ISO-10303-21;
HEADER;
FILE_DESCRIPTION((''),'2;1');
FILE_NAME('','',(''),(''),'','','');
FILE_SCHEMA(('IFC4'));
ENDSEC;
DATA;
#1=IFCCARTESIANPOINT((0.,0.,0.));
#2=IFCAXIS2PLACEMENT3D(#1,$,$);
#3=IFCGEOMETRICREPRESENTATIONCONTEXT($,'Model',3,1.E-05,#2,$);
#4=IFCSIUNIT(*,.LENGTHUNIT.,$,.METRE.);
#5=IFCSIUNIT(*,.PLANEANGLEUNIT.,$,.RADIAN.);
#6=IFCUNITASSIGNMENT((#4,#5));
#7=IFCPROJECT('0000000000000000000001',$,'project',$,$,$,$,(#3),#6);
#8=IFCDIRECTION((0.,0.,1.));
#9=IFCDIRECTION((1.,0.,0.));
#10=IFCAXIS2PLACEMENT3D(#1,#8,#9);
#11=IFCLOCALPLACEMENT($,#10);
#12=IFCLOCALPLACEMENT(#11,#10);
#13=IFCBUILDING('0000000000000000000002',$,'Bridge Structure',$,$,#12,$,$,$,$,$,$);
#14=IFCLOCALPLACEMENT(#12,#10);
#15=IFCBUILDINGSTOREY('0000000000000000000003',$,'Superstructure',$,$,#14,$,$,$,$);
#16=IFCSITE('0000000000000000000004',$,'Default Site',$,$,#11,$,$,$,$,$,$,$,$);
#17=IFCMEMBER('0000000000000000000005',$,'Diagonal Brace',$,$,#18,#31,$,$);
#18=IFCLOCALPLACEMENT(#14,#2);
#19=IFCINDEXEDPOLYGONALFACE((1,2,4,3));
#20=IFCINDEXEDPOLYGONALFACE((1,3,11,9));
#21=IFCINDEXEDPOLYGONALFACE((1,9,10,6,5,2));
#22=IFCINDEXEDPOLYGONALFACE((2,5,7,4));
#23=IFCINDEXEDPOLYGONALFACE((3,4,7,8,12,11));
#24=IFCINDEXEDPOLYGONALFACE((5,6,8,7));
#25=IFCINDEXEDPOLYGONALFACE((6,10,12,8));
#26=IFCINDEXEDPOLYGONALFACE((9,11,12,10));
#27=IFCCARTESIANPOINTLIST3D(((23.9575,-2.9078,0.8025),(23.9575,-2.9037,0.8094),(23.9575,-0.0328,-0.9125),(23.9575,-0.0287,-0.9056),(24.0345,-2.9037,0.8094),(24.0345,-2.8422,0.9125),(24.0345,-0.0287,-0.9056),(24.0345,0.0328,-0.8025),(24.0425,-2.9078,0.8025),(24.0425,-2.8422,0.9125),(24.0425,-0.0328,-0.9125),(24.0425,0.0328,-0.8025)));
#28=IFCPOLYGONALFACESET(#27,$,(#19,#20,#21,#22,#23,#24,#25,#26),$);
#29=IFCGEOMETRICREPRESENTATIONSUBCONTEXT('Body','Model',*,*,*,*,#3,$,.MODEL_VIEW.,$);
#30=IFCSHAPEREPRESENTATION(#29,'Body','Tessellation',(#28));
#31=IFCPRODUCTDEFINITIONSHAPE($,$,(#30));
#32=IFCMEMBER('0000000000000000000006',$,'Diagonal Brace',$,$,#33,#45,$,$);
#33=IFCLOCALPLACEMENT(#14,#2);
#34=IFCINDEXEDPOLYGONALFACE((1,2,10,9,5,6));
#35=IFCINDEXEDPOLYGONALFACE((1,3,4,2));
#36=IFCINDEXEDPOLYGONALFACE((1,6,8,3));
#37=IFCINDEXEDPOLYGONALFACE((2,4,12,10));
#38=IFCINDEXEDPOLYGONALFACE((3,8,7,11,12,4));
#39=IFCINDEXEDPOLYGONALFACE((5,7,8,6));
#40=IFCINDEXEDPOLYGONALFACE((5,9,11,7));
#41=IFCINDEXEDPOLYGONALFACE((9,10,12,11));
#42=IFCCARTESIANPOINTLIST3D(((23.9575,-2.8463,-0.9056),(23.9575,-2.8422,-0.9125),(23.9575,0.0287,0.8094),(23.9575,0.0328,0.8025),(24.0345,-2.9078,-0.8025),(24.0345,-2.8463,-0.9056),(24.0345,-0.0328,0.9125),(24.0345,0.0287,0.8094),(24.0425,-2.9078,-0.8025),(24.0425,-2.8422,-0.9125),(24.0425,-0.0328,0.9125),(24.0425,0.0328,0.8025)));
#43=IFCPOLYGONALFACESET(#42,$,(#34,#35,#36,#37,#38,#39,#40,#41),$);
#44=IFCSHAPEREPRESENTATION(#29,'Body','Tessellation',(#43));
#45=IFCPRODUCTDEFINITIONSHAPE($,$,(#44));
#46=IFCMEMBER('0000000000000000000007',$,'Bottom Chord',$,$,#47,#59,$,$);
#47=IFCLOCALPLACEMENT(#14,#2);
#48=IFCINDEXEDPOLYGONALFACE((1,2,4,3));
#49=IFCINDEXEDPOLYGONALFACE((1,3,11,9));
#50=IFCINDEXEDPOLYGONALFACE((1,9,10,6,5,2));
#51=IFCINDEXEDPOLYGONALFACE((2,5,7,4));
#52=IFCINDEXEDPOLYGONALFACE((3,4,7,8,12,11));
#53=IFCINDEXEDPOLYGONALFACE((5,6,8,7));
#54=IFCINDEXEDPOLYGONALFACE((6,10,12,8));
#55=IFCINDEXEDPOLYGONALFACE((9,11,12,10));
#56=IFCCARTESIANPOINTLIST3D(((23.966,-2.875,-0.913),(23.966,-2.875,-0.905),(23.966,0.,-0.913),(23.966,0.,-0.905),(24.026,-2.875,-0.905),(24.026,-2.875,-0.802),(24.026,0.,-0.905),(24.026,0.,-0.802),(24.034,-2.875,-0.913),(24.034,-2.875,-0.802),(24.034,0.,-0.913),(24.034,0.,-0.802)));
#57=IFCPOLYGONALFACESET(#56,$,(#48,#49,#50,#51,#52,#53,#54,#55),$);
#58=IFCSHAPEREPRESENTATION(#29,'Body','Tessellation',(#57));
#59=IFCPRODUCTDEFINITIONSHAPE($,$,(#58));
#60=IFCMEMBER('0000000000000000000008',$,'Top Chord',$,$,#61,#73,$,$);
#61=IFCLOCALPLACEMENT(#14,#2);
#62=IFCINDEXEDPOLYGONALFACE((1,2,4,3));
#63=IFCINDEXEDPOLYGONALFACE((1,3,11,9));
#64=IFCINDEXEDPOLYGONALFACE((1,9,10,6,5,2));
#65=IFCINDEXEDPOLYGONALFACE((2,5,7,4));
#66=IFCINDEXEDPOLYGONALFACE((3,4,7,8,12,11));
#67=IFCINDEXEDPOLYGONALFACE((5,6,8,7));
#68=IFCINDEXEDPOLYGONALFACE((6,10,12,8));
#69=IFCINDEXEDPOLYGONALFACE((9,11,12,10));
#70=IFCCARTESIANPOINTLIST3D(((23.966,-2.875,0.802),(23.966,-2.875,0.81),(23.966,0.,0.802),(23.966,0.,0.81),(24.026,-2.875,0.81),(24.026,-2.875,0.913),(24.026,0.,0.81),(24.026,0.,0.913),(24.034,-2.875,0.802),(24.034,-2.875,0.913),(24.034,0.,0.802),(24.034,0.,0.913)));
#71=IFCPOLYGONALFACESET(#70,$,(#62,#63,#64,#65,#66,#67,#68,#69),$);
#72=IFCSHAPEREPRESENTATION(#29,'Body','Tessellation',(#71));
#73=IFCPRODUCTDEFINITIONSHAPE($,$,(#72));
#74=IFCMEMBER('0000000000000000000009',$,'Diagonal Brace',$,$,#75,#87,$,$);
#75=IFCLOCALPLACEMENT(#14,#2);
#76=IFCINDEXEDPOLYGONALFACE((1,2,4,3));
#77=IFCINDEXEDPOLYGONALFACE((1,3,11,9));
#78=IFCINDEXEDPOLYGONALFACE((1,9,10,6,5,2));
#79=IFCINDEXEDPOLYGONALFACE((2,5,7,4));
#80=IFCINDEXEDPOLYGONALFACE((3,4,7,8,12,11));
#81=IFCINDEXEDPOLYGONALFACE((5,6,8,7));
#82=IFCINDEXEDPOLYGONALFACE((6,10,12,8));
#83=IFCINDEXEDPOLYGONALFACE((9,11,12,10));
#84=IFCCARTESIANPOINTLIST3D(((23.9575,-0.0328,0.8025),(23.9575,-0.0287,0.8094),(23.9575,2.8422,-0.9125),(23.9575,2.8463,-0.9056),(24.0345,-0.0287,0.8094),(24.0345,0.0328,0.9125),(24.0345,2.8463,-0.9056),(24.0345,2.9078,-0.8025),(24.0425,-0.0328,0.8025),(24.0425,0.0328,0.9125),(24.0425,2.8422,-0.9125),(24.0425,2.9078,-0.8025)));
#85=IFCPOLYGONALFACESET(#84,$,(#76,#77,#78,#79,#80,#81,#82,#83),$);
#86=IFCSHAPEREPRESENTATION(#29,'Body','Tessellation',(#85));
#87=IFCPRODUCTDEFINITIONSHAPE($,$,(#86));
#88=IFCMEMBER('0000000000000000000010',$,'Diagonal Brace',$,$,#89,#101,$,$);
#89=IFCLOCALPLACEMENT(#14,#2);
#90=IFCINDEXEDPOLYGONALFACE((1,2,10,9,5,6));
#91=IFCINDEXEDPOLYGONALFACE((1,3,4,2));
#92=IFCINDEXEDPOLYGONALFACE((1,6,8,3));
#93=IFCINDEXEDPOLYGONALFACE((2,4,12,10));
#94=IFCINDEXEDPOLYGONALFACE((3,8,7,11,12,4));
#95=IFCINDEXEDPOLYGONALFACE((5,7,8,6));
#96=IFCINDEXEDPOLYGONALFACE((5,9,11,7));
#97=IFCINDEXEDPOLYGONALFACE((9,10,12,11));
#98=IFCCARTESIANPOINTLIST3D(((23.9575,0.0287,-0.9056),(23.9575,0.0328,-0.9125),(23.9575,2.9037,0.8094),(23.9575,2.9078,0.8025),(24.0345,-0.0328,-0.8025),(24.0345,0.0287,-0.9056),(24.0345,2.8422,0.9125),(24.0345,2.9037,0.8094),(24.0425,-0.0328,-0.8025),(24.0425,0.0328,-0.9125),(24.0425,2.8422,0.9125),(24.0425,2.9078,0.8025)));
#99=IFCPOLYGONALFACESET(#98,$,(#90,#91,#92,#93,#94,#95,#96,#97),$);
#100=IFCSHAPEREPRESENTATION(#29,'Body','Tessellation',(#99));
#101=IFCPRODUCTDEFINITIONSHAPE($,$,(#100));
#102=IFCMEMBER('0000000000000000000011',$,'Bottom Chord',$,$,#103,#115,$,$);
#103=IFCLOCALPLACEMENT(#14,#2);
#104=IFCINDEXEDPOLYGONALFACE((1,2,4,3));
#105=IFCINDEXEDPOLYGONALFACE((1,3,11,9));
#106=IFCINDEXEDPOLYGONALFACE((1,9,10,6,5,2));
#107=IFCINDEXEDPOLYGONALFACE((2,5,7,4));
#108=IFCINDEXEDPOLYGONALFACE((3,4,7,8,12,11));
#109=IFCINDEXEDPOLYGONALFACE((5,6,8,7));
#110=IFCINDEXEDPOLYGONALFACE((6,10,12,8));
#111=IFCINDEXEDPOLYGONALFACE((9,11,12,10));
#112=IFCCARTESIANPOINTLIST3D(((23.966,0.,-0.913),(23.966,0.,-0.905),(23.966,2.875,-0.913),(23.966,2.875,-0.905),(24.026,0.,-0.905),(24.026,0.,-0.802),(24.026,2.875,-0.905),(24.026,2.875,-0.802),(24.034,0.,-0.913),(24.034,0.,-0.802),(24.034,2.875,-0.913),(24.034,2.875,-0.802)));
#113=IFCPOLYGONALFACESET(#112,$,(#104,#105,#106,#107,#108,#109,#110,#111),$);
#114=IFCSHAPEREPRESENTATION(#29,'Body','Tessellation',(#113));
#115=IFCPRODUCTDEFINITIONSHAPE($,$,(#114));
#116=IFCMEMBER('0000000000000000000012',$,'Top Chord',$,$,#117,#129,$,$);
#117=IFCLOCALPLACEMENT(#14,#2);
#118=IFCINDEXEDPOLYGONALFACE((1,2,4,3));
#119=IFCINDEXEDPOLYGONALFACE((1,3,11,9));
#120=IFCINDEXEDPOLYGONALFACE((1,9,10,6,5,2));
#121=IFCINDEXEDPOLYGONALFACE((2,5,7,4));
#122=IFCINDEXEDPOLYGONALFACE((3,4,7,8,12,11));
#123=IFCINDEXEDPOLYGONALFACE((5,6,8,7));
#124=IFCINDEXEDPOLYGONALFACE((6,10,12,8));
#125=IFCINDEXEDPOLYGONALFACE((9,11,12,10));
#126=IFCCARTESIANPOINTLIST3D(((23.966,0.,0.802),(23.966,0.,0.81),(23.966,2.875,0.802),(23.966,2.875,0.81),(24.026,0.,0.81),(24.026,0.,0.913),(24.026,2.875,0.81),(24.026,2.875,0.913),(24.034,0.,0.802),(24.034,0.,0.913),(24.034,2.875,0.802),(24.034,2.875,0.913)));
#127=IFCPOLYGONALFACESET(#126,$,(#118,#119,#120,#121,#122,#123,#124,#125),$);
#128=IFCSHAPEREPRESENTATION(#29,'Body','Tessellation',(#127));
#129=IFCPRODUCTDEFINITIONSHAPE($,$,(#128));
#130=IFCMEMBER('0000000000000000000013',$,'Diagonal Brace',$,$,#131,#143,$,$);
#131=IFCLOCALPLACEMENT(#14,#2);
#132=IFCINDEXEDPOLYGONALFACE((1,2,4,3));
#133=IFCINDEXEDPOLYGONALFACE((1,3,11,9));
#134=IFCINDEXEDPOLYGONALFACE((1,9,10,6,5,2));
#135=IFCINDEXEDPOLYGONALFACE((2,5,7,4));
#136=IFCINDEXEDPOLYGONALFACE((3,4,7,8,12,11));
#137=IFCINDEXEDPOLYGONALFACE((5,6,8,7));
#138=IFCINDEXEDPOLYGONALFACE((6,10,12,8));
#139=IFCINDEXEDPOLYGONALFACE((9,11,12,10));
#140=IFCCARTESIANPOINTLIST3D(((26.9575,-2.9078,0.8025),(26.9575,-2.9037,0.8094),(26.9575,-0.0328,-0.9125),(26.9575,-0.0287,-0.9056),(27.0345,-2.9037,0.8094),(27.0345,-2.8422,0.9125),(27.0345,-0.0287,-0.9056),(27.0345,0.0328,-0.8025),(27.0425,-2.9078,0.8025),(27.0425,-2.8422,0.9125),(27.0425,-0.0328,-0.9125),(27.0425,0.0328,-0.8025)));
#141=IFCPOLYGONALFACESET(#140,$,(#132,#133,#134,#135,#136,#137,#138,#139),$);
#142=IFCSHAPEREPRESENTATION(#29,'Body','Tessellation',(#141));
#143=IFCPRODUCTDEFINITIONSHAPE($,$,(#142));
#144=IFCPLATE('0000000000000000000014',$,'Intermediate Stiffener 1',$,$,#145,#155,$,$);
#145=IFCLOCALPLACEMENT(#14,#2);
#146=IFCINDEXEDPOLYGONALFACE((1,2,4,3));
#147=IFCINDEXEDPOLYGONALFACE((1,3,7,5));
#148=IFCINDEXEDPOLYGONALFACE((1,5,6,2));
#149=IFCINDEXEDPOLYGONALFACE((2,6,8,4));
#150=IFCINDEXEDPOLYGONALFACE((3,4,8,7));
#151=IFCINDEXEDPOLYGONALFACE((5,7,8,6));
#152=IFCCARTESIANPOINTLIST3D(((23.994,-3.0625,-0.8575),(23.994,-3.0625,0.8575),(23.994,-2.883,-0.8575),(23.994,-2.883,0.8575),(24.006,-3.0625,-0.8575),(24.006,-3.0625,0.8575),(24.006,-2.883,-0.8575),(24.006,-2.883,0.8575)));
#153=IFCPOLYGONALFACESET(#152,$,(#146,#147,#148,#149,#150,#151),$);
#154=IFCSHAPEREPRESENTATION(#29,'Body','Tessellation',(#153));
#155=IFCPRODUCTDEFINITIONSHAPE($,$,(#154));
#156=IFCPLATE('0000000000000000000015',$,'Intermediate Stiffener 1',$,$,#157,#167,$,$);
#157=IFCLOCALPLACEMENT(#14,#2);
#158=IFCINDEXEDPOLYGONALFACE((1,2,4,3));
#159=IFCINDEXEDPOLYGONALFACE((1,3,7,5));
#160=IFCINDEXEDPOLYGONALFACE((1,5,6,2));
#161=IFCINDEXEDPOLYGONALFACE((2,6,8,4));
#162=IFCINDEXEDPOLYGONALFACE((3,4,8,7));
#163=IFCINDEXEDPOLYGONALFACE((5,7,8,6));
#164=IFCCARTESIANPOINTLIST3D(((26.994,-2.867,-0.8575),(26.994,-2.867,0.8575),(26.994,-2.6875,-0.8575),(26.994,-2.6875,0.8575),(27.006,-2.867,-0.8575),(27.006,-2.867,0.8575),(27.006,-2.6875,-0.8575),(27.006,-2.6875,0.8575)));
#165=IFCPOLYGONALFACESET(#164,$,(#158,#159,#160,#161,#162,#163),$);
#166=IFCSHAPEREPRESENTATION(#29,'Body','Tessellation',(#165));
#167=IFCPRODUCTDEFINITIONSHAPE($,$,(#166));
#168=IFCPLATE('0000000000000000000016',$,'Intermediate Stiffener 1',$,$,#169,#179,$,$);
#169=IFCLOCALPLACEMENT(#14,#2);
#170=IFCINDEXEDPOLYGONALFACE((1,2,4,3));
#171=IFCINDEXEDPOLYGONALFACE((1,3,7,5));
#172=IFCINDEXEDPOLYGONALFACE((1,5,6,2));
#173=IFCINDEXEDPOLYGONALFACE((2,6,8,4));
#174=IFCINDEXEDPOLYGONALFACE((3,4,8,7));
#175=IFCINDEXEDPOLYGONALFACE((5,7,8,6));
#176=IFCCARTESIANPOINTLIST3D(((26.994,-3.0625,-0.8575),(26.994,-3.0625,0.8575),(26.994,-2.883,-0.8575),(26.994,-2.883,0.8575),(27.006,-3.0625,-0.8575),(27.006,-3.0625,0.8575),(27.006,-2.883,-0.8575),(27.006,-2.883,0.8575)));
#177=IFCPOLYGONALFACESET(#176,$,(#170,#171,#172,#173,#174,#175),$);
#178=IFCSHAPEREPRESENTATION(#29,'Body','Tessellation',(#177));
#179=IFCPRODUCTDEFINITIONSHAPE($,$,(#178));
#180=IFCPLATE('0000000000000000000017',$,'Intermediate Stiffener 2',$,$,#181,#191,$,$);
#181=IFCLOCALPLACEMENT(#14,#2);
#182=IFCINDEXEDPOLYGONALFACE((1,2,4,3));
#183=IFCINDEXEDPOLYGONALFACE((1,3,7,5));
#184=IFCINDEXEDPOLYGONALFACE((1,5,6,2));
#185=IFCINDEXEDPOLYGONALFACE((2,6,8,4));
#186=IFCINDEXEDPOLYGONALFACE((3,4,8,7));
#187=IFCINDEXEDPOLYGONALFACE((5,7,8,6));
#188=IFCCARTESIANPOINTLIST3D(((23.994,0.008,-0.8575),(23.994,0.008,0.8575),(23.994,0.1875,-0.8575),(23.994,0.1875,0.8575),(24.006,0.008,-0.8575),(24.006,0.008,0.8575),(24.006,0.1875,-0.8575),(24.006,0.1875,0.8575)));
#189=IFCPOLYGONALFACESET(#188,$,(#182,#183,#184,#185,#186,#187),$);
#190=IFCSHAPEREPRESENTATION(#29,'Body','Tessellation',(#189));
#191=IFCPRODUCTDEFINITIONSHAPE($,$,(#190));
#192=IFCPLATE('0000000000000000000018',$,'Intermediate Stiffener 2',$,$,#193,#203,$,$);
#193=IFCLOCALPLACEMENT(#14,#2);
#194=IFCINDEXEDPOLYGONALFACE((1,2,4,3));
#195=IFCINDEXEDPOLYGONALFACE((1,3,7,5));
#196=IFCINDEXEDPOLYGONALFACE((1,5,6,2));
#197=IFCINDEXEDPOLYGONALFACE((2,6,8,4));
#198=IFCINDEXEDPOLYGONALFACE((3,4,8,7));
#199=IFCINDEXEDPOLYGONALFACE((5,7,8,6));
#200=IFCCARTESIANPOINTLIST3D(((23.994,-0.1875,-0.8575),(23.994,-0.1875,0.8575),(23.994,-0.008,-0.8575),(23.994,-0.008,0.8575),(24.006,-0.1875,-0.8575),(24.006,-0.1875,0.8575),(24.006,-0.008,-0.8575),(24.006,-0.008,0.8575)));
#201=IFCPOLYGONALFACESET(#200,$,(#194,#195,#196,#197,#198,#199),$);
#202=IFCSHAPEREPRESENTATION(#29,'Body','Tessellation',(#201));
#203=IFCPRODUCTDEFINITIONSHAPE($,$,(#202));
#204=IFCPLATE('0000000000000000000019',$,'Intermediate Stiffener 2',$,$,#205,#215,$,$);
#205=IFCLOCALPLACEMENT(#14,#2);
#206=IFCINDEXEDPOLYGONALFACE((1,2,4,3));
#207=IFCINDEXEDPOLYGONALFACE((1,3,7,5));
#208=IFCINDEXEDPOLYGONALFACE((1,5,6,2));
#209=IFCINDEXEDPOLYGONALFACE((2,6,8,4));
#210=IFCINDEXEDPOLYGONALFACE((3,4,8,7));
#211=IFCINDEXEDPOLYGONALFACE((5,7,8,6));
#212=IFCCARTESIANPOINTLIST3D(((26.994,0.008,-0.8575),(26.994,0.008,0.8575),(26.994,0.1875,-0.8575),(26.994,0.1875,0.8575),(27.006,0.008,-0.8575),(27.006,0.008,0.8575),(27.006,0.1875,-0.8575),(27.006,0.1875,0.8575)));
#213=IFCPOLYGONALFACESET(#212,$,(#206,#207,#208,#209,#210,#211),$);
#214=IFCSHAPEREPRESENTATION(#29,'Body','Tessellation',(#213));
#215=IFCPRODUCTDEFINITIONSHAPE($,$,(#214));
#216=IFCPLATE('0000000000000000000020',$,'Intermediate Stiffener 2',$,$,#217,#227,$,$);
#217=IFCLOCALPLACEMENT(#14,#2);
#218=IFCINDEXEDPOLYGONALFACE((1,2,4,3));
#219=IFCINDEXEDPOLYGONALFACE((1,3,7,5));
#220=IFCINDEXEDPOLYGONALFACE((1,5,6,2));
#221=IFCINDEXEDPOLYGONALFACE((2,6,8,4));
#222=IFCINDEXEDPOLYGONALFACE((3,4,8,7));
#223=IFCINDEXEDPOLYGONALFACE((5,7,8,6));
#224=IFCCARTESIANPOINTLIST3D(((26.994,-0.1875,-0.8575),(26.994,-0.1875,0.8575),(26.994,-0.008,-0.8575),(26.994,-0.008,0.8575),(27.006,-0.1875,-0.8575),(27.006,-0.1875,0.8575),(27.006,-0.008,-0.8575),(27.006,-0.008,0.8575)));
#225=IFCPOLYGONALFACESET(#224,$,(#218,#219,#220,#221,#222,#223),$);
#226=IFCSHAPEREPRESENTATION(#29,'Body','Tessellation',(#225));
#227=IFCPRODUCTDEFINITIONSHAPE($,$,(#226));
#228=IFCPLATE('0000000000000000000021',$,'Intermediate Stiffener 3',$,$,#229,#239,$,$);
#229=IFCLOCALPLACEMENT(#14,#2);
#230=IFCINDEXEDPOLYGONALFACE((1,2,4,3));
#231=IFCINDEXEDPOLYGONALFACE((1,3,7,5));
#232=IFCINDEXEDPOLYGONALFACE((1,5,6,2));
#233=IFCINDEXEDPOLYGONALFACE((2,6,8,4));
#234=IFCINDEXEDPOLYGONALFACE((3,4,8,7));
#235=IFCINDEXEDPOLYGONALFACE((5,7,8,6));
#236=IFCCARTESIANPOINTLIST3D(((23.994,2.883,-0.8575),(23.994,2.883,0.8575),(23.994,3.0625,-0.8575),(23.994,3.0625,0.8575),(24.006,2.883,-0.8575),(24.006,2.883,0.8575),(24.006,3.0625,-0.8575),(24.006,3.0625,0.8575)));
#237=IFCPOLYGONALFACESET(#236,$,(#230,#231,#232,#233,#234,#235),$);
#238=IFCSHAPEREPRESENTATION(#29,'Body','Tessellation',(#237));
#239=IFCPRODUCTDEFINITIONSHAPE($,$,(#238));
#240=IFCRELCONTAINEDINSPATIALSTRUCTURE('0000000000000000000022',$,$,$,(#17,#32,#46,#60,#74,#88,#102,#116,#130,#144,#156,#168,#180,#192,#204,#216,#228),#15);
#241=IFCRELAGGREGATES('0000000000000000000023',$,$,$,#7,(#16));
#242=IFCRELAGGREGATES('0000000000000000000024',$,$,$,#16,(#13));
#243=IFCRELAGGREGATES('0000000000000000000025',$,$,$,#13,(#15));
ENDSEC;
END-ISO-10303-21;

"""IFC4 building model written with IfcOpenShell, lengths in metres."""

from ifc_helpers import new_model, si_unit, frame, origin, origin_with_axes, origin_2d_with_axis, place, context, subcontext, project, spatial, rectangle, l_section, extrude, element, save


model = new_model("IFC4")

# Units and contexts
model_context = context("Model", 3, precision=1e-05, world=origin())
body_context = subcontext(model_context, "Body", "Model", "MODEL_VIEW")
ifc_project = project(units=[si_unit("LENGTHUNIT", "METRE"), si_unit("PLANEANGLEUNIT", "RADIAN")], contexts=[model_context])

# Site, building, storey
site_placement = place(None, origin_with_axes())
site = spatial("IfcSite", under=ifc_project, at=site_placement, Name="Default Site")
building_placement = place(site_placement, origin_with_axes())
building = spatial("IfcBuilding", under=site, at=building_placement, Name="Bridge Structure")
storey_placement = place(building_placement, origin_with_axes())
storey = spatial("IfcBuildingStorey", under=building, at=storey_placement, Name="Superstructure")

# Members
for number, where, z_axis, x_axis, name in (
    (1, (24.0, -2.875, 0.8575), (0.0, 0.858808, -0.512298), (-1.0, 0.0, 0.0), "Diagonal Brace"),
    (2, (24.0, -2.875, -0.8575), (0.0, 0.858808, 0.512298), (-1.0, 0.0, 0.0), "Diagonal Brace"),
):
    element("IfcMember", number, at=place(storey_placement, frame(where, z_axis=z_axis, x_axis=x_axis)), inside=storey, Name=name, context=body_context, shape_type="SweptSolid", body=[
        extrude(l_section(Depth=0.128, Width=0.085, Thickness=0.008, at=origin_2d_with_axis()), origin_with_axes(), (0.0, 0.0, 1.0), 3.3477),
    ])
for number, where, z_axis, x_axis, name in (
    (3, (24.0, -2.875, -0.8575), (0.0, 1.0, 0.0), (-1.0, 0.0, 0.0), "Bottom Chord"),
    (4, (24.0, -2.875, 0.8575), (0.0, 1.0, 0.0), (-1.0, 0.0, 0.0), "Top Chord"),
):
    element("IfcMember", number, at=place(storey_placement, frame(where, z_axis=z_axis, x_axis=x_axis)), inside=storey, Name=name, context=body_context, shape_type="SweptSolid", body=[
        extrude(l_section(Depth=0.111, Width=0.068, Thickness=0.008, at=origin_2d_with_axis()), origin_with_axes(), (0.0, 0.0, 1.0), 2.875),
    ])
for number, where, z_axis, x_axis, name in (
    (5, (24.0, 0.0, 0.8575), (0.0, 0.858808, -0.512298), (-1.0, 0.0, 0.0), "Diagonal Brace"),
    (6, (24.0, 0.0, -0.8575), (0.0, 0.858808, 0.512298), (-1.0, 0.0, 0.0), "Diagonal Brace"),
):
    element("IfcMember", number, at=place(storey_placement, frame(where, z_axis=z_axis, x_axis=x_axis)), inside=storey, Name=name, context=body_context, shape_type="SweptSolid", body=[
        extrude(l_section(Depth=0.128, Width=0.085, Thickness=0.008, at=origin_2d_with_axis()), origin_with_axes(), (0.0, 0.0, 1.0), 3.3477),
    ])
for number, where, z_axis, x_axis, name in (
    (7, (24.0, 0.0, -0.8575), (0.0, 1.0, 0.0), (-1.0, 0.0, 0.0), "Bottom Chord"),
    (8, (24.0, 0.0, 0.8575), (0.0, 1.0, 0.0), (-1.0, 0.0, 0.0), "Top Chord"),
):
    element("IfcMember", number, at=place(storey_placement, frame(where, z_axis=z_axis, x_axis=x_axis)), inside=storey, Name=name, context=body_context, shape_type="SweptSolid", body=[
        extrude(l_section(Depth=0.111, Width=0.068, Thickness=0.008, at=origin_2d_with_axis()), origin_with_axes(), (0.0, 0.0, 1.0), 2.875),
    ])
member_placement = place(storey_placement, frame((27.0, -2.875, 0.8575), z_axis=(0.0, 0.858808, -0.512298), x_axis=(-1.0, 0.0, 0.0)))
element("IfcMember", 9, at=member_placement, inside=storey, Name="Diagonal Brace", context=body_context, shape_type="SweptSolid", body=[
    extrude(l_section(Depth=0.128, Width=0.085, Thickness=0.008, at=origin_2d_with_axis()), origin_with_axes(), (0.0, 0.0, 1.0), 3.3477),
])

# Plates
for number, where, z_axis, x_axis, name in (
    (10, (24.0, -2.9728, -0.8575), (0.0, 0.0, 1.0), (1.0, 0.0, 0.0), "Intermediate Stiffener 1"),
    (11, (27.0, -2.7772, -0.8575), (0.0, 0.0, 1.0), (1.0, 0.0, 0.0), "Intermediate Stiffener 1"),
    (12, (27.0, -2.9728, -0.8575), (0.0, 0.0, 1.0), (1.0, 0.0, 0.0), "Intermediate Stiffener 1"),
    (13, (24.0, 0.0978, -0.8575), (0.0, 0.0, 1.0), (1.0, 0.0, 0.0), "Intermediate Stiffener 2"),
    (14, (24.0, -0.0978, -0.8575), (0.0, 0.0, 1.0), (1.0, 0.0, 0.0), "Intermediate Stiffener 2"),
    (15, (27.0, 0.0978, -0.8575), (0.0, 0.0, 1.0), (1.0, 0.0, 0.0), "Intermediate Stiffener 2"),
    (16, (27.0, -0.0978, -0.8575), (0.0, 0.0, 1.0), (1.0, 0.0, 0.0), "Intermediate Stiffener 2"),
    (17, (24.0, 2.9728, -0.8575), (0.0, 0.0, 1.0), (1.0, 0.0, 0.0), "Intermediate Stiffener 3"),
):
    element("IfcPlate", number, at=place(storey_placement, frame(where, z_axis=z_axis, x_axis=x_axis)), inside=storey, Name=name, context=body_context, shape_type="SweptSolid", body=[
        extrude(rectangle(XDim=0.012, YDim=0.1795, at=origin_2d_with_axis()), origin_with_axes(), (0.0, 0.0, 1.0), 1.715),
    ])

save(model, "model.ifc")
